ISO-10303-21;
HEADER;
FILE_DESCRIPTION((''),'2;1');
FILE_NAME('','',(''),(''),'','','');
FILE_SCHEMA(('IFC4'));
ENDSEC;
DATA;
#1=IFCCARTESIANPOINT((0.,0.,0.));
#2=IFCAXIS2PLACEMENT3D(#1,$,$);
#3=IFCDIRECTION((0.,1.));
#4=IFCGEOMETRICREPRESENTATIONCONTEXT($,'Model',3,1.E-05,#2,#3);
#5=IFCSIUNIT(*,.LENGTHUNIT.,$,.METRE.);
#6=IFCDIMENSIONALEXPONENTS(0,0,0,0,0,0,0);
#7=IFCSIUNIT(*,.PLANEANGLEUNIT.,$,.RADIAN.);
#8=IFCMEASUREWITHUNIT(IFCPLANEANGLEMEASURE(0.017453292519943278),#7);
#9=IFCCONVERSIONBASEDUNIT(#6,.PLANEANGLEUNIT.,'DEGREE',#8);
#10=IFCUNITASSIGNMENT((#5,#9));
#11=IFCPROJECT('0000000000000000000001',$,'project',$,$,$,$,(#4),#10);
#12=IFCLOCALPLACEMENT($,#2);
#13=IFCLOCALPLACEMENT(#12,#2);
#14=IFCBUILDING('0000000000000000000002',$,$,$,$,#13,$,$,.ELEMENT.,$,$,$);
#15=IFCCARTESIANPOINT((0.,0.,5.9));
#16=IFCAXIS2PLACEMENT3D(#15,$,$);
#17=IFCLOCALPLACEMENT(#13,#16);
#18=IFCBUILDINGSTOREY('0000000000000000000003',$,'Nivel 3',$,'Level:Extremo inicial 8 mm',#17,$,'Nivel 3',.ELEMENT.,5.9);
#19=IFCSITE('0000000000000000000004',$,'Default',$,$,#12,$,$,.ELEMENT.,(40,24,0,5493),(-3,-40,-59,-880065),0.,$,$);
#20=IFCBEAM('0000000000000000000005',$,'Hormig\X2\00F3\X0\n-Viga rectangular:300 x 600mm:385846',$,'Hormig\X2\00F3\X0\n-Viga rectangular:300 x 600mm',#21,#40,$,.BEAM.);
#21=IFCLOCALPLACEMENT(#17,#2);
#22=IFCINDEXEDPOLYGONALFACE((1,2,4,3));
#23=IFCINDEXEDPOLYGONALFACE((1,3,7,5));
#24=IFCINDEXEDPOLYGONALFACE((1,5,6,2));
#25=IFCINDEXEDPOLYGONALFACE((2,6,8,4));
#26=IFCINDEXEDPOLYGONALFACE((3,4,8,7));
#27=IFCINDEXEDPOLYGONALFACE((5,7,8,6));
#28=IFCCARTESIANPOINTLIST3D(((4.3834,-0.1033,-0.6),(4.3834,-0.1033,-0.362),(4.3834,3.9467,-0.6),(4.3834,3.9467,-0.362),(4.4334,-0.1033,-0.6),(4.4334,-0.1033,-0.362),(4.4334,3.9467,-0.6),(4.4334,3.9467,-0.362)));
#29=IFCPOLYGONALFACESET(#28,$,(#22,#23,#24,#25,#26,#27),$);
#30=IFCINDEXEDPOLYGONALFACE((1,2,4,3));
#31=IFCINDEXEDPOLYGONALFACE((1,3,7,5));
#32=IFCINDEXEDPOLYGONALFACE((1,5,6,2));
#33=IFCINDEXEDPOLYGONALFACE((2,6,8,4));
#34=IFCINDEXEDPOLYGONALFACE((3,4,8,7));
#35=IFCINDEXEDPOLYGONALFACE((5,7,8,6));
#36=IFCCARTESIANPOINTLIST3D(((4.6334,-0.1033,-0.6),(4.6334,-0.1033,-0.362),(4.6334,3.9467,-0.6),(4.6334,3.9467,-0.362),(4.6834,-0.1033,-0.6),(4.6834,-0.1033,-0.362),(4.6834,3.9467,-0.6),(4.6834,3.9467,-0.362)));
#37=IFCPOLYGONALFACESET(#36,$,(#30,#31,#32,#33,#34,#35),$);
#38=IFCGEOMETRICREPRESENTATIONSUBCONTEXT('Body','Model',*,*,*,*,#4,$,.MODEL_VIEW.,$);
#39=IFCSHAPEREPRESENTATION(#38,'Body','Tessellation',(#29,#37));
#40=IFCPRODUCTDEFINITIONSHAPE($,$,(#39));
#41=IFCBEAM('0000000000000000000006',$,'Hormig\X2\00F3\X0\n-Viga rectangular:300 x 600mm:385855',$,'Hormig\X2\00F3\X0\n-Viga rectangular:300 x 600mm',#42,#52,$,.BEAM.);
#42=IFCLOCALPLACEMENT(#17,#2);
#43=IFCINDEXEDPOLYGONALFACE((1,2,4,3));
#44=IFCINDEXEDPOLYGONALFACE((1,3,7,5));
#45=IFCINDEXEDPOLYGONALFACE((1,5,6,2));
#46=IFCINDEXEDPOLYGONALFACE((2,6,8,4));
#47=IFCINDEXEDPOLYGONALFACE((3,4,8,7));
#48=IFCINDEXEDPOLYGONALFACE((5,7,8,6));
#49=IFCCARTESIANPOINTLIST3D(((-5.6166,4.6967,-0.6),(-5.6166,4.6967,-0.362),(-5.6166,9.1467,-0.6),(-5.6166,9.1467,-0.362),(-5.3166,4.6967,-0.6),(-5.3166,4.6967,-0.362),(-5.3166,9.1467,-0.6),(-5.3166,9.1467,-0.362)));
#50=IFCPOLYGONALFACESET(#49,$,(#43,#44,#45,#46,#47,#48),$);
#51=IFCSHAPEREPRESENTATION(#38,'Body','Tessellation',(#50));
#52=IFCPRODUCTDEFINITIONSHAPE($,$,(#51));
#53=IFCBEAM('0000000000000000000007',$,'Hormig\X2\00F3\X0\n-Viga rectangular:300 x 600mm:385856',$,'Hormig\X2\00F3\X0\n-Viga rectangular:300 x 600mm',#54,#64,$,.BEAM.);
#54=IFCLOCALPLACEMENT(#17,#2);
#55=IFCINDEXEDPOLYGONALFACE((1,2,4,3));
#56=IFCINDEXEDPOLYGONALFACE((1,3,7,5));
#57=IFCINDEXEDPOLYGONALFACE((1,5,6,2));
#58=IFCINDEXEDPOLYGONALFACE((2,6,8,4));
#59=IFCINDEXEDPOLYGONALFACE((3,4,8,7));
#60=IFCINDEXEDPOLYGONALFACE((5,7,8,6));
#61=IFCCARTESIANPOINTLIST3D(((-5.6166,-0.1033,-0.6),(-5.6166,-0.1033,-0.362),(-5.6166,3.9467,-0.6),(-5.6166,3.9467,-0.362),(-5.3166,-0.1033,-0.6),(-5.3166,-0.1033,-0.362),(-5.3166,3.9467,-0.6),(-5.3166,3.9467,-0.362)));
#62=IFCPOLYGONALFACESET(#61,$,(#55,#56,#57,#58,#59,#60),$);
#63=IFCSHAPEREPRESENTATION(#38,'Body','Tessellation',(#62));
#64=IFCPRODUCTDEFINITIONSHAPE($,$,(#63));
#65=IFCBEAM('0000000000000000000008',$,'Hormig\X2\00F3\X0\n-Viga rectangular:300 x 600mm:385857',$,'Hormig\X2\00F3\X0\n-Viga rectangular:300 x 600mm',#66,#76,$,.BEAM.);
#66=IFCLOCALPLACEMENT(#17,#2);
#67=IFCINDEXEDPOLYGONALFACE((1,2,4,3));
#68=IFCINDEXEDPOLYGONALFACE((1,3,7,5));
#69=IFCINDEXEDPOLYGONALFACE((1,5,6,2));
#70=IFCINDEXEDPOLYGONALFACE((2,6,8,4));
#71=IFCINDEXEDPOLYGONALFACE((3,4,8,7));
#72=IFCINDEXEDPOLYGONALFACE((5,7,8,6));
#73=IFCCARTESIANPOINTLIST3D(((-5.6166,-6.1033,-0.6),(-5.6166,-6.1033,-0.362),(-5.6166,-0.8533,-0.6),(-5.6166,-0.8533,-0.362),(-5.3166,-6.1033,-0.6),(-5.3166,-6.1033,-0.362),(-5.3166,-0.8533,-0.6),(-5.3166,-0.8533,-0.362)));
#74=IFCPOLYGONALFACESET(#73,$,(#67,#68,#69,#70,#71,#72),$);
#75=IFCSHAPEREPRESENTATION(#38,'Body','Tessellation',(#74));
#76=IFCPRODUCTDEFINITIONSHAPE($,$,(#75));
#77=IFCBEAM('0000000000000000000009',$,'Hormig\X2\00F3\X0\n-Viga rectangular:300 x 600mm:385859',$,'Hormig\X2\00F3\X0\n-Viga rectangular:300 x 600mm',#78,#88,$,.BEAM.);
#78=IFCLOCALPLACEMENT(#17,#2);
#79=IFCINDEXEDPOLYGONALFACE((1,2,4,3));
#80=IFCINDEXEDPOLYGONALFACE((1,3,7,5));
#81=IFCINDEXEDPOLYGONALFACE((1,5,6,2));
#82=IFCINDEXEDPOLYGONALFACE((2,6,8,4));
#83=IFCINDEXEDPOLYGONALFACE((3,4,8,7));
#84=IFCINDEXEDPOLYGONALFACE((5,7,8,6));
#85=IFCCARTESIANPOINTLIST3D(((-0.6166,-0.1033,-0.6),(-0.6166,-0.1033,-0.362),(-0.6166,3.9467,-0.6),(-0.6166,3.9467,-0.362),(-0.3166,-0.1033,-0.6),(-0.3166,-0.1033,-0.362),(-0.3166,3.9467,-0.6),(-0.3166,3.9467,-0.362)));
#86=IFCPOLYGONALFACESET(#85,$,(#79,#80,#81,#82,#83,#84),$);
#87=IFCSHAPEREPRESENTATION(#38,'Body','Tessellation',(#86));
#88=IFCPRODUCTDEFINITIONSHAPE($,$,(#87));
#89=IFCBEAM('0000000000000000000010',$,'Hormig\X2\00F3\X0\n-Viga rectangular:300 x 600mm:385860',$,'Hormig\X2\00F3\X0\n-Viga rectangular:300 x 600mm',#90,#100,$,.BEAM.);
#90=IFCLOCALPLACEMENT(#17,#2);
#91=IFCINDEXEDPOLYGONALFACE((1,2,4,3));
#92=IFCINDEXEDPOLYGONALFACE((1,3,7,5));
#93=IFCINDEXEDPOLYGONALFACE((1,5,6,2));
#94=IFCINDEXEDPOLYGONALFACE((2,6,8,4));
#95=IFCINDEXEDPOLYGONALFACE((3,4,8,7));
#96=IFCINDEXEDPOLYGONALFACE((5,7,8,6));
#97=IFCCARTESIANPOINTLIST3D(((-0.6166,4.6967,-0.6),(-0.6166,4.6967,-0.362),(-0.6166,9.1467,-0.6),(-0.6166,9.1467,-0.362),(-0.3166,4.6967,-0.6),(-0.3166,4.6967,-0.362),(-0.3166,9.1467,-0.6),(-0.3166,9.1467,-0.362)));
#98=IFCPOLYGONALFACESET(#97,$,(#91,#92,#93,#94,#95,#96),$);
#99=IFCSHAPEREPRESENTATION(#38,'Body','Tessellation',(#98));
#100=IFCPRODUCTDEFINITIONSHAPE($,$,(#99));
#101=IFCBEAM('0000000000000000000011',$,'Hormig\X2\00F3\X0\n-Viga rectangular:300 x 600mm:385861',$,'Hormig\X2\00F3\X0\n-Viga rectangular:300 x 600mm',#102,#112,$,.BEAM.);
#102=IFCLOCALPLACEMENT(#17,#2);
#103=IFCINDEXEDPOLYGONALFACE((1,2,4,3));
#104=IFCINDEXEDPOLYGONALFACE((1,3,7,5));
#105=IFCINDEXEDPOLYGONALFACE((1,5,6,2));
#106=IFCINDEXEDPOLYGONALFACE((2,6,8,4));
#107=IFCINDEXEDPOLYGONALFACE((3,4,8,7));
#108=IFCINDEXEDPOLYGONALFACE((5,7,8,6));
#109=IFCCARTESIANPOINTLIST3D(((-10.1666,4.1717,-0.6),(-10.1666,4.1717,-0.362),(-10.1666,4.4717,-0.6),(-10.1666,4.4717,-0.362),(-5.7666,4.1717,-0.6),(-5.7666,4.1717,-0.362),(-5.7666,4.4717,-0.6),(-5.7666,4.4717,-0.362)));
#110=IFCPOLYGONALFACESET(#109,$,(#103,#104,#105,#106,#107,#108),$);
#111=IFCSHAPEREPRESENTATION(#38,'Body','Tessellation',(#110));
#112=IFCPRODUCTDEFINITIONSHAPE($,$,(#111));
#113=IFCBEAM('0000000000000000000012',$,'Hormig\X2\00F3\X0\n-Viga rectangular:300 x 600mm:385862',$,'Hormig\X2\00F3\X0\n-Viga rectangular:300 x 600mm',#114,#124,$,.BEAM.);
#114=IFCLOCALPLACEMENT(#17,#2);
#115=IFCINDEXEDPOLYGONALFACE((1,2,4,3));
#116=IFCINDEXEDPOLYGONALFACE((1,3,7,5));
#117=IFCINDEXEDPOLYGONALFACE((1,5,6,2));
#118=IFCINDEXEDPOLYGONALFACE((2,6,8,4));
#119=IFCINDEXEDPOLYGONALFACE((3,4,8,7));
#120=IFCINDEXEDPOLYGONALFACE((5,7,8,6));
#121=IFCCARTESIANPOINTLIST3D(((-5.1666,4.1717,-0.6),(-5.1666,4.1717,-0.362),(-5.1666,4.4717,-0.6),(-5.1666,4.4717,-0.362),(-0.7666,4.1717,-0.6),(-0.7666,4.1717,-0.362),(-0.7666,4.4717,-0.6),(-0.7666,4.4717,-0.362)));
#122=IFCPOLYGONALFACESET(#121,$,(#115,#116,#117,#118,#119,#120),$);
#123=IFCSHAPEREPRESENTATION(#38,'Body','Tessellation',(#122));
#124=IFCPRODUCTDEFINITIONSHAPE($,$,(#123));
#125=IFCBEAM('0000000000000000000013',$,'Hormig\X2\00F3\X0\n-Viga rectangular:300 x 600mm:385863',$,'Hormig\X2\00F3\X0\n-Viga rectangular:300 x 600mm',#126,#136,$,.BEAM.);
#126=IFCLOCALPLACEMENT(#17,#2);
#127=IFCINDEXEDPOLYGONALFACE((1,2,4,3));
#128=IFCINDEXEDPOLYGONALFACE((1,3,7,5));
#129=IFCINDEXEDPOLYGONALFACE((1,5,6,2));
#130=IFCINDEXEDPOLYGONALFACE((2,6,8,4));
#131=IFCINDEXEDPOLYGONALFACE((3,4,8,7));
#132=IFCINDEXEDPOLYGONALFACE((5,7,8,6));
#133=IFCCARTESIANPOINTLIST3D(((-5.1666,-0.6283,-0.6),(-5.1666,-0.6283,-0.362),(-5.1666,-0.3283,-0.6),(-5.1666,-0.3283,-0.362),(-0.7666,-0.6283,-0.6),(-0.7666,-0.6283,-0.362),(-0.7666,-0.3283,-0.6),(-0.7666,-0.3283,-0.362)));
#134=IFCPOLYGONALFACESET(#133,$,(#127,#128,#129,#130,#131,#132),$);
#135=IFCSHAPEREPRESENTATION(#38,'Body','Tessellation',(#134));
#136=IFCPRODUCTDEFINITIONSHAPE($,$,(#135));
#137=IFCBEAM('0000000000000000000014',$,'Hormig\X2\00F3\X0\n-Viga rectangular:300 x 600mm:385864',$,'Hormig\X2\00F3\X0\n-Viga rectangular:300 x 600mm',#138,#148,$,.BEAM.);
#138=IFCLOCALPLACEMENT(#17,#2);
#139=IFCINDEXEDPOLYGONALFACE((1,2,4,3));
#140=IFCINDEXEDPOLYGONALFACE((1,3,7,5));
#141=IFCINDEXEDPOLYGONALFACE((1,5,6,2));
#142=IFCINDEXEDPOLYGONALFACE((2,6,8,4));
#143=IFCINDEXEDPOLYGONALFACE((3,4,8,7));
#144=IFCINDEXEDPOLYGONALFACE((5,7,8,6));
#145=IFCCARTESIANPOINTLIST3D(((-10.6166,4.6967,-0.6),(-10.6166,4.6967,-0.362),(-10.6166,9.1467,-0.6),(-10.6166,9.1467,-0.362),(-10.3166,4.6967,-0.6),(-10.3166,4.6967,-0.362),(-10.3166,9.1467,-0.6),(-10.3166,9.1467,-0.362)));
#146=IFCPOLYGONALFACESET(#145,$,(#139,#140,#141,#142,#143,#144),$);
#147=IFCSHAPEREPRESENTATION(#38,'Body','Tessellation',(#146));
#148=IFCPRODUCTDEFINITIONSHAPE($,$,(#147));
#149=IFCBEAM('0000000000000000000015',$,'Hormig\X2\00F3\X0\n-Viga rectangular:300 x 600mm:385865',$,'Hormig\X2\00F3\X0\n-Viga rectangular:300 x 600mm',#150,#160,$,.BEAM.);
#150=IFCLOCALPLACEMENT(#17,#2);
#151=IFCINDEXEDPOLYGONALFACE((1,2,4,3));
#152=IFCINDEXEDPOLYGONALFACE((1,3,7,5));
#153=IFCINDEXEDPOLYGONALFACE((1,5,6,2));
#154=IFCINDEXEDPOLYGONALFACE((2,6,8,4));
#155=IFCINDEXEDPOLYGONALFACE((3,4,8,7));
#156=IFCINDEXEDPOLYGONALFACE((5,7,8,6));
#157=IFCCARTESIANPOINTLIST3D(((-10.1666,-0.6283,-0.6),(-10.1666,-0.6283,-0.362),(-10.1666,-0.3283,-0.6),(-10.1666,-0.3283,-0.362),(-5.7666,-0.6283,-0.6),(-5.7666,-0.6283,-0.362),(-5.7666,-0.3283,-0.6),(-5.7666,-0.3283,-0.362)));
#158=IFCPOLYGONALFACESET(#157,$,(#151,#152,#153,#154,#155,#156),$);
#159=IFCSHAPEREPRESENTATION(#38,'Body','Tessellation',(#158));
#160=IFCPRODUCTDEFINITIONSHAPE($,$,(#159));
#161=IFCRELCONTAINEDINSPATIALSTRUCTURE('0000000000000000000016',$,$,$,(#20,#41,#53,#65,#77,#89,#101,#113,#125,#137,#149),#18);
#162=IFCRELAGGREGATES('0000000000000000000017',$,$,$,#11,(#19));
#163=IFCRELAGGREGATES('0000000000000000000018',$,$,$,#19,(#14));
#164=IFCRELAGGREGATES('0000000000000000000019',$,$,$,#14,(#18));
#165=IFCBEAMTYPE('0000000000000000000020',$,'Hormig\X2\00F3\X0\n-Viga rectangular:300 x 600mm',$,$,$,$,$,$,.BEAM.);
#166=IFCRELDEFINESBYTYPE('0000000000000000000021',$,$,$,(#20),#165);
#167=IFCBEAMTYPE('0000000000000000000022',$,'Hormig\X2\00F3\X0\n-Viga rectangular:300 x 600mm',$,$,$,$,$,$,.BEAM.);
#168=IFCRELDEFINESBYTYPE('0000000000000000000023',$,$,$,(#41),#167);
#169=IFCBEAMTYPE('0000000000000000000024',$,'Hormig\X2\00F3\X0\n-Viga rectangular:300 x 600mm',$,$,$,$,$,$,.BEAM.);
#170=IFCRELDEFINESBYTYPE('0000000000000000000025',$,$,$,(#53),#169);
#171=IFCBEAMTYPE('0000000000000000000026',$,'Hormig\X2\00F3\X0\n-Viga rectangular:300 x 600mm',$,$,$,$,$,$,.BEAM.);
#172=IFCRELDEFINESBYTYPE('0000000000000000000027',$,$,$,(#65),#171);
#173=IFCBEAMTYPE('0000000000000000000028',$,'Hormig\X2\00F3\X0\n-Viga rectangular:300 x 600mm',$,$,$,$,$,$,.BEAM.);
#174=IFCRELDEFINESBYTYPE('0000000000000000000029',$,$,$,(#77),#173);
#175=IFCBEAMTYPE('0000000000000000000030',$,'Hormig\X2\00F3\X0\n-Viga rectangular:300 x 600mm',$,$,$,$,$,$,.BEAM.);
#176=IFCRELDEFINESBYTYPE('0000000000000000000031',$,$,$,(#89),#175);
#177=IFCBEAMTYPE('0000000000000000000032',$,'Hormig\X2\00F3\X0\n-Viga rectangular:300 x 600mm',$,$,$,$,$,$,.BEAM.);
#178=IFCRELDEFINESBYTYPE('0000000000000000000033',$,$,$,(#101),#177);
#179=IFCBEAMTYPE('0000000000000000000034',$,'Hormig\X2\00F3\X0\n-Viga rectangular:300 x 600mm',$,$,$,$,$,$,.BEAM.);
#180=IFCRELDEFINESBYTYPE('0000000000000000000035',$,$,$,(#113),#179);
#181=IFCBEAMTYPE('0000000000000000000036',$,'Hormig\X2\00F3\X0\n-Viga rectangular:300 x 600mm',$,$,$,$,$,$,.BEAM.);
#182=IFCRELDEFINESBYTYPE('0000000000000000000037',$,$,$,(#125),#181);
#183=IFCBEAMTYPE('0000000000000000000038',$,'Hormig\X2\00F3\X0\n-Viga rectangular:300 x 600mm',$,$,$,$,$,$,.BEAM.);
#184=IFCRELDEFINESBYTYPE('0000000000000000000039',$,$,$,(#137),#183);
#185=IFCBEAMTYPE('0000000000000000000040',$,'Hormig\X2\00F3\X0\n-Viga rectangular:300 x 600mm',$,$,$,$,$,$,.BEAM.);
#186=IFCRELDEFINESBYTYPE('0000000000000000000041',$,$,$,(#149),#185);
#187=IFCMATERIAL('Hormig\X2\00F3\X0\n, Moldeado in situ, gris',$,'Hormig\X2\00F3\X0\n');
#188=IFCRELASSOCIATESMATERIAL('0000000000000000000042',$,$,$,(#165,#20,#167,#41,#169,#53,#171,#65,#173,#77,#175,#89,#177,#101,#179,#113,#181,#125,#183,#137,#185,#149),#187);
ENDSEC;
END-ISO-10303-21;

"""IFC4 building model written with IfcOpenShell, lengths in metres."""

from ifc_helpers import new_model, entity, si_unit, converted_unit, direction, frame, origin, place, context, subcontext, project, spatial, indexed_curve, outline, extrude, source, transform, mapped, material, type_object, type_shapes, element, save


model = new_model("IFC4")

# Units and contexts
model_context = context("Model", 3, precision=1e-05, world=origin(), true_north=direction((0.0, 1.0)))
body_context = subcontext(model_context, "Body", "Model", "MODEL_VIEW")
ifc_project = project(units=[si_unit("LENGTHUNIT", "METRE"), converted_unit("PLANEANGLEUNIT", "DEGREE", entity("IfcPlaneAngleMeasure", 0.017453292519943278), si_unit("PLANEANGLEUNIT", "RADIAN"), dimensions=[0, 0, 0, 0, 0, 0, 0])], contexts=[model_context])

# Site, building, storey
site_placement = place(None, origin())
site = spatial("IfcSite", under=ifc_project, at=site_placement, Name="Default", CompositionType="ELEMENT", RefLatitude=(40, 24, 0, 5493), RefLongitude=(-3, -40, -59, -880065), RefElevation=0.0)
building_placement = place(site_placement, origin())
building = spatial("IfcBuilding", under=site, at=building_placement, CompositionType="ELEMENT")
storey_placement = place(building_placement, frame((0.0, 0.0, 5.9)))
storey = spatial("IfcBuildingStorey", under=building, at=storey_placement, Name="Nivel 3", ObjectType="Level:Extremo inicial 8 mm", LongName="Nivel 3", CompositionType="ELEMENT", Elevation=5.9)

# Shared definitions
ifc_material_1 = material(Name="Hormigón, Moldeado in situ, gris", Category="Hormigón")

# Beams
beam_type_1 = type_object("IfcBeamType", Name="Hormigón-Viga rectangular:300 x 600mm", PredefinedType="BEAM", material=ifc_material_1)
shared_shape_1 = source(origin(), body_context, "Body", "SweptSolid", [
    extrude(outline(indexed_curve([(-0.025, -0.119), (0.025, -0.119), (0.025, 0.119), (-0.025, 0.119), (-0.025, -0.119)], self_intersect=False)), frame((4.4084, 3.9467, 5.419), z_axis=(0.0, -1.0, 0.0), x_axis=(-1.0, 0.0, 0.0)), (0.0, 0.0, 1.0), 4.05),
    extrude(outline(indexed_curve([(-0.025, -0.119), (0.025, -0.119), (0.025, 0.119), (-0.025, 0.119), (-0.025, -0.119)], self_intersect=False)), frame((4.6584, 3.9467, 5.419), z_axis=(0.0, -1.0, 0.0), x_axis=(-1.0, 0.0, 0.0)), (0.0, 0.0, 1.0), 4.05),
])
type_shapes(beam_type_1, [shared_shape_1])
beam_1_placement = place(storey_placement, frame((0.0, 0.0, -5.9)))
element("IfcBeam", 1, at=beam_1_placement, inside=storey, type_object=beam_type_1, material=ifc_material_1, Name="Hormigón-Viga rectangular:300 x 600mm:385846", ObjectType="Hormigón-Viga rectangular:300 x 600mm", PredefinedType="BEAM", context=body_context, shape_type="MappedRepresentation", body=[
    mapped(shared_shape_1, transform((0.0, 0.0, 0.0), scale=1.0)),
])
beam_type_2 = type_object("IfcBeamType", Name="Hormigón-Viga rectangular:300 x 600mm", PredefinedType="BEAM", material=ifc_material_1)
shared_shape_2 = source(origin(), body_context, "Body", "SweptSolid", [
    extrude(outline(indexed_curve([(-0.15, -0.119), (0.15, -0.119), (0.15, 0.119), (-0.15, 0.119), (-0.15, -0.119)], self_intersect=False)), frame((-5.4666, 9.1467, 5.419), z_axis=(0.0, -1.0, 0.0), x_axis=(-1.0, 0.0, 0.0)), (0.0, 0.0, 1.0), 4.45),
])
type_shapes(beam_type_2, [shared_shape_2])
beam_2_placement = place(storey_placement, frame((0.0, 0.0, -5.9)))
element("IfcBeam", 2, at=beam_2_placement, inside=storey, type_object=beam_type_2, material=ifc_material_1, Name="Hormigón-Viga rectangular:300 x 600mm:385855", ObjectType="Hormigón-Viga rectangular:300 x 600mm", PredefinedType="BEAM", context=body_context, shape_type="MappedRepresentation", body=[
    mapped(shared_shape_2, transform((0.0, 0.0, 0.0), scale=1.0)),
])
beam_type_3 = type_object("IfcBeamType", Name="Hormigón-Viga rectangular:300 x 600mm", PredefinedType="BEAM", material=ifc_material_1)
shared_shape_3 = source(origin(), body_context, "Body", "SweptSolid", [
    extrude(outline(indexed_curve([(-0.15, -0.119), (0.15, -0.119), (0.15, 0.119), (-0.15, 0.119), (-0.15, -0.119)], self_intersect=False)), frame((-5.4666, 3.9467, 5.419), z_axis=(0.0, -1.0, 0.0), x_axis=(-1.0, 0.0, 0.0)), (0.0, 0.0, 1.0), 4.05),
])
type_shapes(beam_type_3, [shared_shape_3])
beam_3_placement = place(storey_placement, frame((0.0, 0.0, -5.9)))
element("IfcBeam", 3, at=beam_3_placement, inside=storey, type_object=beam_type_3, material=ifc_material_1, Name="Hormigón-Viga rectangular:300 x 600mm:385856", ObjectType="Hormigón-Viga rectangular:300 x 600mm", PredefinedType="BEAM", context=body_context, shape_type="MappedRepresentation", body=[
    mapped(shared_shape_3, transform((0.0, 0.0, 0.0), scale=1.0)),
])
beam_type_4 = type_object("IfcBeamType", Name="Hormigón-Viga rectangular:300 x 600mm", PredefinedType="BEAM", material=ifc_material_1)
shared_shape_4 = source(origin(), body_context, "Body", "SweptSolid", [
    extrude(outline(indexed_curve([(-0.15, -0.119), (0.15, -0.119), (0.15, 0.119), (-0.15, 0.119), (-0.15, -0.119)], self_intersect=False)), frame((-5.4666, -6.1033, 5.419), z_axis=(0.0, 1.0, 0.0), x_axis=(-1.0, 0.0, 0.0)), (0.0, 0.0, 1.0), 5.25),
])
type_shapes(beam_type_4, [shared_shape_4])
beam_4_placement = place(storey_placement, frame((0.0, 0.0, -5.9)))
element("IfcBeam", 4, at=beam_4_placement, inside=storey, type_object=beam_type_4, material=ifc_material_1, Name="Hormigón-Viga rectangular:300 x 600mm:385857", ObjectType="Hormigón-Viga rectangular:300 x 600mm", PredefinedType="BEAM", context=body_context, shape_type="MappedRepresentation", body=[
    mapped(shared_shape_4, transform((0.0, 0.0, 0.0), scale=1.0)),
])
beam_type_5 = type_object("IfcBeamType", Name="Hormigón-Viga rectangular:300 x 600mm", PredefinedType="BEAM", material=ifc_material_1)
shared_shape_5 = source(origin(), body_context, "Body", "SweptSolid", [
    extrude(outline(indexed_curve([(-0.15, -0.119), (0.15, -0.119), (0.15, 0.119), (-0.15, 0.119), (-0.15, -0.119)], self_intersect=False)), frame((-0.4666, -0.1033, 5.419), z_axis=(0.0, 1.0, 0.0), x_axis=(-1.0, 0.0, 0.0)), (0.0, 0.0, 1.0), 4.05),
])
type_shapes(beam_type_5, [shared_shape_5])
beam_5_placement = place(storey_placement, frame((0.0, 0.0, -5.9)))
element("IfcBeam", 5, at=beam_5_placement, inside=storey, type_object=beam_type_5, material=ifc_material_1, Name="Hormigón-Viga rectangular:300 x 600mm:385859", ObjectType="Hormigón-Viga rectangular:300 x 600mm", PredefinedType="BEAM", context=body_context, shape_type="MappedRepresentation", body=[
    mapped(shared_shape_5, transform((0.0, 0.0, 0.0), scale=1.0)),
])
beam_type_6 = type_object("IfcBeamType", Name="Hormigón-Viga rectangular:300 x 600mm", PredefinedType="BEAM", material=ifc_material_1)
shared_shape_6 = source(origin(), body_context, "Body", "SweptSolid", [
    extrude(outline(indexed_curve([(-0.15, -0.119), (0.15, -0.119), (0.15, 0.119), (-0.15, 0.119), (-0.15, -0.119)], self_intersect=False)), frame((-0.4666, 9.1467, 5.419), z_axis=(0.0, -1.0, 0.0), x_axis=(-1.0, 0.0, 0.0)), (0.0, 0.0, 1.0), 4.45),
])
type_shapes(beam_type_6, [shared_shape_6])
beam_6_placement = place(storey_placement, frame((0.0, 0.0, -5.9)))
element("IfcBeam", 6, at=beam_6_placement, inside=storey, type_object=beam_type_6, material=ifc_material_1, Name="Hormigón-Viga rectangular:300 x 600mm:385860", ObjectType="Hormigón-Viga rectangular:300 x 600mm", PredefinedType="BEAM", context=body_context, shape_type="MappedRepresentation", body=[
    mapped(shared_shape_6, transform((0.0, 0.0, 0.0), scale=1.0)),
])
beam_type_7 = type_object("IfcBeamType", Name="Hormigón-Viga rectangular:300 x 600mm", PredefinedType="BEAM", material=ifc_material_1)
shared_shape_7 = source(origin(), body_context, "Body", "SweptSolid", [
    extrude(outline(indexed_curve([(-0.119, -0.15), (0.119, -0.15), (0.119, 0.15), (-0.119, 0.15), (-0.119, -0.15)], self_intersect=False)), frame((-10.1666, 4.3217, 5.419), z_axis=(1.0, 0.0, 0.0), x_axis=(0.0, 0.0, -1.0)), (0.0, 0.0, 1.0), 4.4),
])
type_shapes(beam_type_7, [shared_shape_7])
beam_7_placement = place(storey_placement, frame((0.0, 0.0, -5.9)))
element("IfcBeam", 7, at=beam_7_placement, inside=storey, type_object=beam_type_7, material=ifc_material_1, Name="Hormigón-Viga rectangular:300 x 600mm:385861", ObjectType="Hormigón-Viga rectangular:300 x 600mm", PredefinedType="BEAM", context=body_context, shape_type="MappedRepresentation", body=[
    mapped(shared_shape_7, transform((0.0, 0.0, 0.0), scale=1.0)),
])
beam_type_8 = type_object("IfcBeamType", Name="Hormigón-Viga rectangular:300 x 600mm", PredefinedType="BEAM", material=ifc_material_1)
shared_shape_8 = source(origin(), body_context, "Body", "SweptSolid", [
    extrude(outline(indexed_curve([(-0.119, -0.15), (0.119, -0.15), (0.119, 0.15), (-0.119, 0.15), (-0.119, -0.15)], self_intersect=False)), frame((-5.1666, 4.3217, 5.419), z_axis=(1.0, 0.0, 0.0), x_axis=(0.0, 0.0, -1.0)), (0.0, 0.0, 1.0), 4.4),
])
type_shapes(beam_type_8, [shared_shape_8])
beam_8_placement = place(storey_placement, frame((0.0, 0.0, -5.9)))
element("IfcBeam", 8, at=beam_8_placement, inside=storey, type_object=beam_type_8, material=ifc_material_1, Name="Hormigón-Viga rectangular:300 x 600mm:385862", ObjectType="Hormigón-Viga rectangular:300 x 600mm", PredefinedType="BEAM", context=body_context, shape_type="MappedRepresentation", body=[
    mapped(shared_shape_8, transform((0.0, 0.0, 0.0), scale=1.0)),
])
beam_type_9 = type_object("IfcBeamType", Name="Hormigón-Viga rectangular:300 x 600mm", PredefinedType="BEAM", material=ifc_material_1)
shared_shape_9 = source(origin(), body_context, "Body", "SweptSolid", [
    extrude(outline(indexed_curve([(-0.119, -0.15), (0.119, -0.15), (0.119, 0.15), (-0.119, 0.15), (-0.119, -0.15)], self_intersect=False)), frame((-0.7666, -0.4783, 5.419), z_axis=(-1.0, 0.0, 0.0), x_axis=(0.0, 0.0, -1.0)), (0.0, 0.0, 1.0), 4.4),
])
type_shapes(beam_type_9, [shared_shape_9])
beam_9_placement = place(storey_placement, frame((0.0, 0.0, -5.9)))
element("IfcBeam", 9, at=beam_9_placement, inside=storey, type_object=beam_type_9, material=ifc_material_1, Name="Hormigón-Viga rectangular:300 x 600mm:385863", ObjectType="Hormigón-Viga rectangular:300 x 600mm", PredefinedType="BEAM", context=body_context, shape_type="MappedRepresentation", body=[
    mapped(shared_shape_9, transform((0.0, 0.0, 0.0), scale=1.0)),
])
beam_type_10 = type_object("IfcBeamType", Name="Hormigón-Viga rectangular:300 x 600mm", PredefinedType="BEAM", material=ifc_material_1)
shared_shape_10 = source(origin(), body_context, "Body", "SweptSolid", [
    extrude(outline(indexed_curve([(-0.15, -0.119), (0.15, -0.119), (0.15, 0.119), (-0.15, 0.119), (-0.15, -0.119)], self_intersect=False)), frame((-10.4666, 4.6967, 5.419), z_axis=(0.0, 1.0, 0.0), x_axis=(-1.0, 0.0, 0.0)), (0.0, 0.0, 1.0), 4.45),
])
type_shapes(beam_type_10, [shared_shape_10])
beam_10_placement = place(storey_placement, frame((0.0, 0.0, -5.9)))
element("IfcBeam", 10, at=beam_10_placement, inside=storey, type_object=beam_type_10, material=ifc_material_1, Name="Hormigón-Viga rectangular:300 x 600mm:385864", ObjectType="Hormigón-Viga rectangular:300 x 600mm", PredefinedType="BEAM", context=body_context, shape_type="MappedRepresentation", body=[
    mapped(shared_shape_10, transform((0.0, 0.0, 0.0), scale=1.0)),
])
beam_type_11 = type_object("IfcBeamType", Name="Hormigón-Viga rectangular:300 x 600mm", PredefinedType="BEAM", material=ifc_material_1)
shared_shape_11 = source(origin(), body_context, "Body", "SweptSolid", [
    extrude(outline(indexed_curve([(-0.119, -0.15), (0.119, -0.15), (0.119, 0.15), (-0.119, 0.15), (-0.119, -0.15)], self_intersect=False)), frame((-10.1666, -0.4783, 5.419), z_axis=(1.0, 0.0, 0.0), x_axis=(0.0, 0.0, -1.0)), (0.0, 0.0, 1.0), 4.4),
])
type_shapes(beam_type_11, [shared_shape_11])
beam_11_placement = place(storey_placement, frame((0.0, 0.0, -5.9)))
element("IfcBeam", 11, at=beam_11_placement, inside=storey, type_object=beam_type_11, material=ifc_material_1, Name="Hormigón-Viga rectangular:300 x 600mm:385865", ObjectType="Hormigón-Viga rectangular:300 x 600mm", PredefinedType="BEAM", context=body_context, shape_type="MappedRepresentation", body=[
    mapped(shared_shape_11, transform((0.0, 0.0, 0.0), scale=1.0)),
])

save(model, "model.ifc")
